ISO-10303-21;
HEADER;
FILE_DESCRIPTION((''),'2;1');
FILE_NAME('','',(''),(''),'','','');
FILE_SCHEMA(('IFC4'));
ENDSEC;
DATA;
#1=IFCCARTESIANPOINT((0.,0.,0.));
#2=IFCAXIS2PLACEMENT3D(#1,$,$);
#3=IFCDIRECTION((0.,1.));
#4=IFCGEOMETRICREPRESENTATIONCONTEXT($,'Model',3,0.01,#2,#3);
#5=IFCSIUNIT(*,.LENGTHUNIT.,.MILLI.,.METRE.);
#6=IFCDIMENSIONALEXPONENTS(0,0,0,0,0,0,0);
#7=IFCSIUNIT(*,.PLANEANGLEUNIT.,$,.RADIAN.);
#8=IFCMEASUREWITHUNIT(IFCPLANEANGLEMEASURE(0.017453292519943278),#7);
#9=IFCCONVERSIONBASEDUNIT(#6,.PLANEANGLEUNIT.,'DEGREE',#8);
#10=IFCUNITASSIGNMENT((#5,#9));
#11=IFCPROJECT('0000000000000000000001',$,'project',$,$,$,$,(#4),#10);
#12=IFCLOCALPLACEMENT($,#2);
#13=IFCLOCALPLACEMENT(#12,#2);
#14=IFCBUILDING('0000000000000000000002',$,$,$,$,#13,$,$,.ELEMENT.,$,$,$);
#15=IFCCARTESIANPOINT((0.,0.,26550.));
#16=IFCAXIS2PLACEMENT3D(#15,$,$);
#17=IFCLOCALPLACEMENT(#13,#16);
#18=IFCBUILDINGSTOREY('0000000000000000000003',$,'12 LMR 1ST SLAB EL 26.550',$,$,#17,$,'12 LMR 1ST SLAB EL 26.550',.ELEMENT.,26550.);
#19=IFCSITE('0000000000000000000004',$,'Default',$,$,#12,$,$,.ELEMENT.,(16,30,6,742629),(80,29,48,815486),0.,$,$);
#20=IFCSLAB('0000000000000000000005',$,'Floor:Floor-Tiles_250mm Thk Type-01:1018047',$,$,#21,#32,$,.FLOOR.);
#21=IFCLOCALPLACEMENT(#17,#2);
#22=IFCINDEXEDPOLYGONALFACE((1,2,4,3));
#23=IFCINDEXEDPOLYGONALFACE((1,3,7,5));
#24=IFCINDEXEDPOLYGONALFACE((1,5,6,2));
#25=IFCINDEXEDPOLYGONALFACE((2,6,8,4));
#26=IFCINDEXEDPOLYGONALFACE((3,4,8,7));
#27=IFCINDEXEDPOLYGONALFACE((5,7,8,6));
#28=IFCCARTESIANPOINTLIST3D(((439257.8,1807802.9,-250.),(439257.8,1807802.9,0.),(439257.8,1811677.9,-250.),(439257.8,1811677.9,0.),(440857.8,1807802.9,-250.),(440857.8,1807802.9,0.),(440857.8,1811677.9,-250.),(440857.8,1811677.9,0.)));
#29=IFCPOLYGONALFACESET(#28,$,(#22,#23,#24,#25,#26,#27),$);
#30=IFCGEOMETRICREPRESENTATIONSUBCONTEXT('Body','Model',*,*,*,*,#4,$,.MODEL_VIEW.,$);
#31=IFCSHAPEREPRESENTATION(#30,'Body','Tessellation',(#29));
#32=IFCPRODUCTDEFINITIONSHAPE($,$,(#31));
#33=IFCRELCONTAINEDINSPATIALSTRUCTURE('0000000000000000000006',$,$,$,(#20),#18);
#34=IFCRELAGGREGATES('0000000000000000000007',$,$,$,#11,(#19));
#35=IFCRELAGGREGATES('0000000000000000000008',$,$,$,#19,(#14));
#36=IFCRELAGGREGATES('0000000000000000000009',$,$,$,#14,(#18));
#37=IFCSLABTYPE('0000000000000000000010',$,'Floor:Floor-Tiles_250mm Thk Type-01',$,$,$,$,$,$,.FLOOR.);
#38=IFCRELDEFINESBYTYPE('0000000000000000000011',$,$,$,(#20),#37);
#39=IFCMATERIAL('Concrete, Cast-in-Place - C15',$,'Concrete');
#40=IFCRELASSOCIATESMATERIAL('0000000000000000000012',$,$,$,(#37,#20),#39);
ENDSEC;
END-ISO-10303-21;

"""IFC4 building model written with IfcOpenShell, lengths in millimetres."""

from ifc_helpers import new_model, entity, si_unit, converted_unit, direction, frame, origin, place, context, subcontext, project, spatial, indexed_curve, outline, extrude, material, type_object, element, save


model = new_model("IFC4")

# Units and contexts
model_context = context("Model", 3, precision=0.01, world=origin(), true_north=direction((0.0, 1.0)))
body_context = subcontext(model_context, "Body", "Model", "MODEL_VIEW")
ifc_project = project(units=[si_unit("LENGTHUNIT", "METRE", prefix="MILLI"), converted_unit("PLANEANGLEUNIT", "DEGREE", entity("IfcPlaneAngleMeasure", 0.017453292519943278), si_unit("PLANEANGLEUNIT", "RADIAN"), dimensions=[0, 0, 0, 0, 0, 0, 0])], contexts=[model_context])

# Site, building, storey
site_placement = place(None, origin())
site = spatial("IfcSite", under=ifc_project, at=site_placement, Name="Default", CompositionType="ELEMENT", RefLatitude=(16, 30, 6, 742629), RefLongitude=(80, 29, 48, 815486), RefElevation=0.0)
building_placement = place(site_placement, origin())
building = spatial("IfcBuilding", under=site, at=building_placement, CompositionType="ELEMENT")
storey_placement = place(building_placement, frame((0.0, 0.0, 26550.0)))
storey = spatial("IfcBuildingStorey", under=building, at=storey_placement, Name="12 LMR 1ST SLAB EL 26.550", LongName="12 LMR 1ST SLAB EL 26.550", CompositionType="ELEMENT", Elevation=26550.0)

# Slab
ifc_material_1 = material(Name="Concrete, Cast-in-Place - C15", Category="Concrete")
slab_type = type_object("IfcSlabType", Name="Floor:Floor-Tiles_250mm Thk Type-01", PredefinedType="FLOOR", material=ifc_material_1)
slab_placement = place(storey_placement, origin())
element("IfcSlab", 1, at=slab_placement, inside=storey, type_object=slab_type, material=ifc_material_1, Name="Floor:Floor-Tiles_250mm Thk Type-01:1018047", PredefinedType="FLOOR", context=body_context, shape_type="SweptSolid", body=[
    extrude(outline(indexed_curve([(-1937.5, -800.0), (1937.5, -800.0), (1937.5, 800.0), (-1937.5, 800.0), (-1937.5, -800.0)], self_intersect=False)), frame((440057.8, 1809740.4, 0.0), z_axis=(0.0, 0.0, -1.0), x_axis=(0.0, 1.0, 0.0)), (0.0, 0.0, 1.0), 250.0),
])

save(model, "model.ifc")
